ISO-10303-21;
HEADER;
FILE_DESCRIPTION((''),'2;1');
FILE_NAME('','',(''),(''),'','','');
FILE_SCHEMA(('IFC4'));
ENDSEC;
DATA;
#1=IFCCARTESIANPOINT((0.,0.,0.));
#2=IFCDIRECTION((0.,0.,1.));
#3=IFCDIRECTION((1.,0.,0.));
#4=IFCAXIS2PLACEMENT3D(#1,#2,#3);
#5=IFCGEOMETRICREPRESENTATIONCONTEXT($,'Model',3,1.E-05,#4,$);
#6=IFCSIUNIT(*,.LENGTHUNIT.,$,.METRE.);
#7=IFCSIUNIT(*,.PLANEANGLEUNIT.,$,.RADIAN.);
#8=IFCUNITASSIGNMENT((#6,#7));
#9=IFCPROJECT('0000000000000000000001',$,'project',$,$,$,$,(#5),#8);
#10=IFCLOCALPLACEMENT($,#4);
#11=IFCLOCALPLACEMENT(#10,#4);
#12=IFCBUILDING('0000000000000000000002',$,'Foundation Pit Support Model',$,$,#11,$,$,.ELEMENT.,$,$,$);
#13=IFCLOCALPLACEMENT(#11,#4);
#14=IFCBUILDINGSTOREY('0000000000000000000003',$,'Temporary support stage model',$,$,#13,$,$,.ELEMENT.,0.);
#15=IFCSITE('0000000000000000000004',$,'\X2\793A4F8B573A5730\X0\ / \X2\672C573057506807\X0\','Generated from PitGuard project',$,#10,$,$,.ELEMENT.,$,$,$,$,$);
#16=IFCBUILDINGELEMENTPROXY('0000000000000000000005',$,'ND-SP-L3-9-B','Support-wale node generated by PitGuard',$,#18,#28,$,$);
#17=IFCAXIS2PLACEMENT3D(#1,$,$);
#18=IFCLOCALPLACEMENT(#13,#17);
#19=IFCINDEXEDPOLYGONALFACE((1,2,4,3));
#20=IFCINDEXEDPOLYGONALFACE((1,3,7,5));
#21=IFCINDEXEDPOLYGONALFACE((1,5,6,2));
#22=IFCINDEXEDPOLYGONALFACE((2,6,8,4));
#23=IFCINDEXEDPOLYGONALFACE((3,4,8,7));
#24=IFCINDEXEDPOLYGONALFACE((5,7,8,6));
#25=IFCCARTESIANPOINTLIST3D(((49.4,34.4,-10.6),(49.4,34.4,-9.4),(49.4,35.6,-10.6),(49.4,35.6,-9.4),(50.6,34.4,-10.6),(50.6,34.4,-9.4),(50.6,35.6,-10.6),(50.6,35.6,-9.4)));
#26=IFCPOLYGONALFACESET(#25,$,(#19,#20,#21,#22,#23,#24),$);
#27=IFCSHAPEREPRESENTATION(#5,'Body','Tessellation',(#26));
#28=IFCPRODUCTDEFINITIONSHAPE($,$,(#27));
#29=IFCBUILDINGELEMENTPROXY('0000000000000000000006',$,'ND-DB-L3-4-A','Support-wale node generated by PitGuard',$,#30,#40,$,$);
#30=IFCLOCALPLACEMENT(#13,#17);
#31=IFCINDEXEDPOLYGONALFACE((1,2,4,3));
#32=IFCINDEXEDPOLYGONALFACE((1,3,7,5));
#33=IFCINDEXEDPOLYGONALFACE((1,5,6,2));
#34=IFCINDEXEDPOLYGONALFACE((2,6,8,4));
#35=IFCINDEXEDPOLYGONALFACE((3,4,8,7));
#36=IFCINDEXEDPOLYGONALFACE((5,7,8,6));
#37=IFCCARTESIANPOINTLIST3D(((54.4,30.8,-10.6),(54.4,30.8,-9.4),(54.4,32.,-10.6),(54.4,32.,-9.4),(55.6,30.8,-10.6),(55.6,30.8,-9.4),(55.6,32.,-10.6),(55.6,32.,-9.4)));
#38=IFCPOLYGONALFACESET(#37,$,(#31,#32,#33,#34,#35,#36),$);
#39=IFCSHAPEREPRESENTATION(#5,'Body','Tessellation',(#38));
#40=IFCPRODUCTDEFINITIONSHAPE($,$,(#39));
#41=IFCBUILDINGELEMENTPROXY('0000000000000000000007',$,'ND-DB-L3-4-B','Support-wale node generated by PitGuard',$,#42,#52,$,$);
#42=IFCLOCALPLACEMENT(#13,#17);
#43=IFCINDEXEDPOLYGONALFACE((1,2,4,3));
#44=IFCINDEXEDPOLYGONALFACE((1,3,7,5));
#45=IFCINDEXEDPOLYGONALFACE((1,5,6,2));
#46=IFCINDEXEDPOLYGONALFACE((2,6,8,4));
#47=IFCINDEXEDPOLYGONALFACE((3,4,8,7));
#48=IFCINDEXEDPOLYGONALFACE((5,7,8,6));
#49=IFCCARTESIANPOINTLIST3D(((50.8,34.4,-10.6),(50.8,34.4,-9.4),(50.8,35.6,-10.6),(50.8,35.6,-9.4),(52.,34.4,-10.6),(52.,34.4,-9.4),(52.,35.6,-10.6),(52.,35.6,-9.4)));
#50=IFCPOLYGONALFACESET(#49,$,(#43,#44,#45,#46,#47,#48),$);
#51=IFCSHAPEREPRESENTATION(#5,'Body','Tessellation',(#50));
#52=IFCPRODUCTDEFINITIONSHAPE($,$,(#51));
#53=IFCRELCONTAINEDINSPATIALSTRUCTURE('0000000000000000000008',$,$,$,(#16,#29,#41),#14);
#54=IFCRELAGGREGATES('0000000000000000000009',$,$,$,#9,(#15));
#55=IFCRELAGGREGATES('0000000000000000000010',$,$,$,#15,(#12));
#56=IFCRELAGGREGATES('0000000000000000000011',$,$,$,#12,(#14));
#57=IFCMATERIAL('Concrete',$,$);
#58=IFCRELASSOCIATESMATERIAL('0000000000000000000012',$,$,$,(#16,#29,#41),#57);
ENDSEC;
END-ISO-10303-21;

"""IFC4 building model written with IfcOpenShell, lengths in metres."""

from ifc_helpers import new_model, si_unit, frame, origin_with_axes, origin_2d, place, context, project, spatial, rectangle, extrude, material, element, save


model = new_model("IFC4")

# Units and contexts
model_context = context("Model", 3, precision=1e-05, world=origin_with_axes())
ifc_project = project(units=[si_unit("LENGTHUNIT", "METRE"), si_unit("PLANEANGLEUNIT", "RADIAN")], contexts=[model_context])

# Site, building, storey
site_placement = place(None, origin_with_axes())
site = spatial("IfcSite", under=ifc_project, at=site_placement, Name="示例场地 / 本地坐标", Description="Generated from PitGuard project", CompositionType="ELEMENT")
building_placement = place(site_placement, origin_with_axes())
building = spatial("IfcBuilding", under=site, at=building_placement, Name="Foundation Pit Support Model", CompositionType="ELEMENT")
storey_placement = place(building_placement, origin_with_axes())
storey = spatial("IfcBuildingStorey", under=building, at=storey_placement, Name="Temporary support stage model", CompositionType="ELEMENT", Elevation=0.0)

# Shared definitions
ifc_material_1 = material(Name="Concrete")

# Building element proxies
for number, where, z_axis, x_axis, name in (
    (1, (50.0, 35.0, -10.6), (0.0, 0.0, 1.0), (1.0, 0.0, 0.0), "ND-SP-L3-9-B"),
    (2, (55.0, 31.4, -10.6), (0.0, 0.0, 1.0), (1.0, 0.0, 0.0), "ND-DB-L3-4-A"),
    (3, (51.4, 35.0, -10.6), (0.0, 0.0, 1.0), (1.0, 0.0, 0.0), "ND-DB-L3-4-B"),
):
    element("IfcBuildingElementProxy", number, at=place(storey_placement, frame(where, z_axis=z_axis, x_axis=x_axis)), inside=storey, material=ifc_material_1, Name=name, Description="Support-wale node generated by PitGuard", context=model_context, shape_type="SweptSolid", body=[
        extrude(rectangle(XDim=1.2, YDim=1.2, at=origin_2d()), origin_with_axes(), (0.0, 0.0, 1.0), 1.2),
    ])

save(model, "model.ifc")
